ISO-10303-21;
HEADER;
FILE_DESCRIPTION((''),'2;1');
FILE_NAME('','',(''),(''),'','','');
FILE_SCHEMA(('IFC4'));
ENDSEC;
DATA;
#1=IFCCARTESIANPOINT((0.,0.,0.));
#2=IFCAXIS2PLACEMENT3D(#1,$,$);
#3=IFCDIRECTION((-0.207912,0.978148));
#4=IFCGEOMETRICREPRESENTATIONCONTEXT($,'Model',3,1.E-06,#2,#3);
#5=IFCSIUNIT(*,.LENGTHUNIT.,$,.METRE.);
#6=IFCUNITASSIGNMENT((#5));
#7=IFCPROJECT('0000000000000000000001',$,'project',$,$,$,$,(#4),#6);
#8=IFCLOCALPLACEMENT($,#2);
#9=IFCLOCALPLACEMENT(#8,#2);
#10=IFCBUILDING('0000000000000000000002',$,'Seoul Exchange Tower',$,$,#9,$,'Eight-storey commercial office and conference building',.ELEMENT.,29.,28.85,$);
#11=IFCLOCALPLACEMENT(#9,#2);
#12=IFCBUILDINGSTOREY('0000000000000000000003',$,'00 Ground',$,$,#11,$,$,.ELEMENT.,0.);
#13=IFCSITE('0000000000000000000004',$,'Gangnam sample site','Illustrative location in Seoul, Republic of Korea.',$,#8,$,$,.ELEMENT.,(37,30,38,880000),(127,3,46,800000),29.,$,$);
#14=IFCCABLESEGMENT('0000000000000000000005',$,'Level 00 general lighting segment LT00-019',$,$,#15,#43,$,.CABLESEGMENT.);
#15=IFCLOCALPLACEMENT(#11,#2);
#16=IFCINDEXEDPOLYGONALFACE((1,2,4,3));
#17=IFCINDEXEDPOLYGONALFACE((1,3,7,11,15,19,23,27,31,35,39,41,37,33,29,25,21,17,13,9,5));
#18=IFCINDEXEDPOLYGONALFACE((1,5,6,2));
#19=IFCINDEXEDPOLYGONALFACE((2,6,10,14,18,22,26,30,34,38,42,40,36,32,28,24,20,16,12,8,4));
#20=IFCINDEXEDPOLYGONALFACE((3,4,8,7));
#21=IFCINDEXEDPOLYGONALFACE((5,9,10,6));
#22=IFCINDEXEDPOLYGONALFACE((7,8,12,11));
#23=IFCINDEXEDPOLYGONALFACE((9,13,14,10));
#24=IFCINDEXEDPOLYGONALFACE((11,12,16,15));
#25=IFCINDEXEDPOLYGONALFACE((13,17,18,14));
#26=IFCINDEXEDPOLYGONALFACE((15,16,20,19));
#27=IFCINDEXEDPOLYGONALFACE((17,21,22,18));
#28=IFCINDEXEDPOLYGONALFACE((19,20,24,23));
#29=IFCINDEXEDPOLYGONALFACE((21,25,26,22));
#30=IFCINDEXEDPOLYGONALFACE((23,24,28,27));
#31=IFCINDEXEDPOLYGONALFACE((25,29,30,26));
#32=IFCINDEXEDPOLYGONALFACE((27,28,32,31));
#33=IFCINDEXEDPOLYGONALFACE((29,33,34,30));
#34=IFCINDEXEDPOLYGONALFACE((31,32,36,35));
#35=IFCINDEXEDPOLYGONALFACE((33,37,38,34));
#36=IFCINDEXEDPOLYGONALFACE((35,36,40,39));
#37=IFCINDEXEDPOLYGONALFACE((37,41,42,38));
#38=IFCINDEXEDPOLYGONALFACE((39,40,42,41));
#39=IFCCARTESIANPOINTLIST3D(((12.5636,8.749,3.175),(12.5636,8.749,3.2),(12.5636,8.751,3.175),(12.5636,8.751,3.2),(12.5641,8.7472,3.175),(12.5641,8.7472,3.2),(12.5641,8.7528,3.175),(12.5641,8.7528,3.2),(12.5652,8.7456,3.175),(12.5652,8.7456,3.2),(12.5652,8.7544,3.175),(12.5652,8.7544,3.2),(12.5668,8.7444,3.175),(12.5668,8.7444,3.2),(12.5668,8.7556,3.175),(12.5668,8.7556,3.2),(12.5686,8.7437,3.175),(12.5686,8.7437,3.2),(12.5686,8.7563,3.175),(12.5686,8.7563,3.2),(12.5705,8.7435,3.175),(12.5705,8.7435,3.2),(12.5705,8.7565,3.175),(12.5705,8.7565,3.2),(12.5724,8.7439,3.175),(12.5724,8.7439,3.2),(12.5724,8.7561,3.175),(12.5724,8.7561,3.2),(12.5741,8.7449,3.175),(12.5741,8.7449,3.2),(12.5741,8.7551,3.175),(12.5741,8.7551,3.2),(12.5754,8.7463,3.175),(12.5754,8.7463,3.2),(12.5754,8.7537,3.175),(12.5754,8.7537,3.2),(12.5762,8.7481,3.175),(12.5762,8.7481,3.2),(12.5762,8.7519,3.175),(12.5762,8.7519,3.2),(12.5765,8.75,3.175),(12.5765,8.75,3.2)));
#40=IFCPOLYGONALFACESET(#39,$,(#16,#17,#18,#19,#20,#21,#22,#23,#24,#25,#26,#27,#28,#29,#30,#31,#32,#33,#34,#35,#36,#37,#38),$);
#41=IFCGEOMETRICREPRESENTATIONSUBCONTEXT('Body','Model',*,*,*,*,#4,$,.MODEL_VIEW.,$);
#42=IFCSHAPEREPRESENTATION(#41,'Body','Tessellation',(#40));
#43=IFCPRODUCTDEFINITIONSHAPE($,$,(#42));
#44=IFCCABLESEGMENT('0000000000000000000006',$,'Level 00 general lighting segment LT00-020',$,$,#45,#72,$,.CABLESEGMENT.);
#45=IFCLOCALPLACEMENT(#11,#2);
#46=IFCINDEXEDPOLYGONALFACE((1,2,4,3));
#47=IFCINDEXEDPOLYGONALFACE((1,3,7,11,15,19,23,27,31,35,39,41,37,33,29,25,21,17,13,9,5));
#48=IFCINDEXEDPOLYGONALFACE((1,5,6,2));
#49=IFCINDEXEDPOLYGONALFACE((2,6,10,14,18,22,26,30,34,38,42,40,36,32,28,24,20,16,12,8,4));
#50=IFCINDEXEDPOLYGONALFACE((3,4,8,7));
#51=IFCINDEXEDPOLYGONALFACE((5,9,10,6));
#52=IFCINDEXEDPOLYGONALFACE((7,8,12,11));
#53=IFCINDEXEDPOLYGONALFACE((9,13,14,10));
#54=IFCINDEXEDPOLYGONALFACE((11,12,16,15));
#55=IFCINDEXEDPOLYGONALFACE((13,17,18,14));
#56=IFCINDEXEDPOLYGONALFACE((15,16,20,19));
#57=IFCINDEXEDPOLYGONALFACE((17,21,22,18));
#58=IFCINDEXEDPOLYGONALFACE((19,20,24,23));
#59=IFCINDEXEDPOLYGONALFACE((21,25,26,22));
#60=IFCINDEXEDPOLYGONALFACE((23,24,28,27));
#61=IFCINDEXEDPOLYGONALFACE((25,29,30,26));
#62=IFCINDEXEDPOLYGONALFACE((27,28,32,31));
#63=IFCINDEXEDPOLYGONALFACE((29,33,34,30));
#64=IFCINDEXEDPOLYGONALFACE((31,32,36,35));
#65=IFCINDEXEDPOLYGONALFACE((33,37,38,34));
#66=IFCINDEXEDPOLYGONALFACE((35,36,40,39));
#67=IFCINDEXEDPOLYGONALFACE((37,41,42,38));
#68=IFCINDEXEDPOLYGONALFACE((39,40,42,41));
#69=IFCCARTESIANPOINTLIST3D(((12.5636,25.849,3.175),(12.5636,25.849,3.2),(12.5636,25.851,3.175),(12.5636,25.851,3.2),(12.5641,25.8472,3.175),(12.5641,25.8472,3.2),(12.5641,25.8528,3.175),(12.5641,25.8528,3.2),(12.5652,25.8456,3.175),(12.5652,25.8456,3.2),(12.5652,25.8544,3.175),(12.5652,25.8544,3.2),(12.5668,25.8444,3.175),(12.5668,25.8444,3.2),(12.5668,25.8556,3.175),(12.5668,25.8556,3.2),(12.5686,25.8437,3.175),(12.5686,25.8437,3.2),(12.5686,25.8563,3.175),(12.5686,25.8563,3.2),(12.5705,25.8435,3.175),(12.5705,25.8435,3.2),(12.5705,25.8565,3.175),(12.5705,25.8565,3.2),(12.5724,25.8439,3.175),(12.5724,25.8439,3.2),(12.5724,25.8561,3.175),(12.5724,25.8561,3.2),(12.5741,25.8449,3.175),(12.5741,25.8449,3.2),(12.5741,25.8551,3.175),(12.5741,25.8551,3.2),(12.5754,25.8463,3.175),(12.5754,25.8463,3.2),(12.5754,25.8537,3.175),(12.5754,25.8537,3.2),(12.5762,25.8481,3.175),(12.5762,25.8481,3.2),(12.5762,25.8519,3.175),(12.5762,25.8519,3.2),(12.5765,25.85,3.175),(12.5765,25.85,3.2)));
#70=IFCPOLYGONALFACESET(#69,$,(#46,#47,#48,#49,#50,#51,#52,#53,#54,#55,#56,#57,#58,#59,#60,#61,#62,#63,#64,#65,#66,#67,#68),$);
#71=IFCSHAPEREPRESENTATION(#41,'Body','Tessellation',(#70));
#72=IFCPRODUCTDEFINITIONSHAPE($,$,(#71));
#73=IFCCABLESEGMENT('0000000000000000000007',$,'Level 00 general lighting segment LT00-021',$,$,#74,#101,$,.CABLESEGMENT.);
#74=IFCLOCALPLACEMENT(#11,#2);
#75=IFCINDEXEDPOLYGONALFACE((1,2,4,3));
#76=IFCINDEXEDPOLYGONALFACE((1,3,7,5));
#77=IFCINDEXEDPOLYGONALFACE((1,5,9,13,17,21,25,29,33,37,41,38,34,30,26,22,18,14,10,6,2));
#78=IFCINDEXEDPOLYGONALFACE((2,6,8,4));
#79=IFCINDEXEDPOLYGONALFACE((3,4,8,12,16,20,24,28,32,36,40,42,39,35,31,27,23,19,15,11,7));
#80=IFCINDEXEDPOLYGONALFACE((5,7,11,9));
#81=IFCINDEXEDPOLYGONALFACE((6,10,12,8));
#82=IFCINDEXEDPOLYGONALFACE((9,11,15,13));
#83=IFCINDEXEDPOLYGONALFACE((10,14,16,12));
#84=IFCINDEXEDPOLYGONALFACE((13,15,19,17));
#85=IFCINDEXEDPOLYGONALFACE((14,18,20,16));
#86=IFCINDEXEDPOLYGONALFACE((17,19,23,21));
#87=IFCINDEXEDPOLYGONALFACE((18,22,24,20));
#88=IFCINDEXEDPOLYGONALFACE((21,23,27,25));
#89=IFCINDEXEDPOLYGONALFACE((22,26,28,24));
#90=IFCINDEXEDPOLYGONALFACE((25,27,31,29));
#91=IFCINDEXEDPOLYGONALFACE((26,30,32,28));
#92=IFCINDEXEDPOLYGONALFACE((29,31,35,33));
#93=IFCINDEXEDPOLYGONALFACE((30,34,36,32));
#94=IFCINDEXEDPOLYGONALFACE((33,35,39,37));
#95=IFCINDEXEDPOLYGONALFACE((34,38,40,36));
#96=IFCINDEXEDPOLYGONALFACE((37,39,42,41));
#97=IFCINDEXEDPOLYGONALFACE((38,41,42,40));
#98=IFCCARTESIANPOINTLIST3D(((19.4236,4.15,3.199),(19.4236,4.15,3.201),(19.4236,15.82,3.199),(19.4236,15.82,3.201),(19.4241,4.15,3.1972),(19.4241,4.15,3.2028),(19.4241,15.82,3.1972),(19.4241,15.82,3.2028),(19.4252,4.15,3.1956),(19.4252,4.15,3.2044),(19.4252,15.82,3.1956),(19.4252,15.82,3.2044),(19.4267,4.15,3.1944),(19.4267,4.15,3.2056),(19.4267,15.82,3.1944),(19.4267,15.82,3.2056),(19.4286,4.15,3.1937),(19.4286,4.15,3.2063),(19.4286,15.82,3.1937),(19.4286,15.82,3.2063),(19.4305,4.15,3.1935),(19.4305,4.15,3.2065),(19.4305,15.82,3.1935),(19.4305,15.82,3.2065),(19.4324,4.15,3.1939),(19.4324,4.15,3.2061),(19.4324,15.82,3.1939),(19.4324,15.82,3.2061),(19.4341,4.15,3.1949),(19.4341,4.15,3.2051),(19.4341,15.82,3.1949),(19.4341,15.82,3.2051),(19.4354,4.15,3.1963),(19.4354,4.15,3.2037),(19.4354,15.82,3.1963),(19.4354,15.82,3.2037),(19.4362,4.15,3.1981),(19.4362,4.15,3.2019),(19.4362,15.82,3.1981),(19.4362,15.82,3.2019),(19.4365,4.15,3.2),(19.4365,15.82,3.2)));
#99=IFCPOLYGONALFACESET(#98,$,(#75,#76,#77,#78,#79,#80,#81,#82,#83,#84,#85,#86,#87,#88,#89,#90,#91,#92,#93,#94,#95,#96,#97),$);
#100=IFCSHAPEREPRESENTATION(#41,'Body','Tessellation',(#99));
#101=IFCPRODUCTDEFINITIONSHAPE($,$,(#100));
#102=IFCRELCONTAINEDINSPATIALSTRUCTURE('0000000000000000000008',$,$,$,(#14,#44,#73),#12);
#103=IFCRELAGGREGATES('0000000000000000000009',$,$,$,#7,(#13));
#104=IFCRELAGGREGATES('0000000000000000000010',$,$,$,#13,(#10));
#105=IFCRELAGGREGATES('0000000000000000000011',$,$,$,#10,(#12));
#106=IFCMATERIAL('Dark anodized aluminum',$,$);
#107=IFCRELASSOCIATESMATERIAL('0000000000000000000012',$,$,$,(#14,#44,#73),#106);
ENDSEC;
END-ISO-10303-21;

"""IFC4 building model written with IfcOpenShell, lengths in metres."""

from ifc_helpers import new_model, si_unit, direction, frame, origin, place, context, subcontext, project, spatial, circle, extrude, material, element, save


model = new_model("IFC4")

# Units and contexts
model_context = context("Model", 3, precision=1e-06, world=origin(), true_north=direction((-0.207912, 0.978148)))
body_context = subcontext(model_context, "Body", "Model", "MODEL_VIEW")
ifc_project = project(units=[si_unit("LENGTHUNIT", "METRE")], contexts=[model_context])

# Site, building, storey
site_placement = place(None, origin())
site = spatial("IfcSite", under=ifc_project, at=site_placement, Name="Gangnam sample site", Description="Illustrative location in Seoul, Republic of Korea.", CompositionType="ELEMENT", RefLatitude=(37, 30, 38, 880000), RefLongitude=(127, 3, 46, 800000), RefElevation=29.0)
building_placement = place(site_placement, origin())
building = spatial("IfcBuilding", under=site, at=building_placement, Name="Seoul Exchange Tower", LongName="Eight-storey commercial office and conference building", CompositionType="ELEMENT", ElevationOfRefHeight=29.0, ElevationOfTerrain=28.85)
storey_placement = place(building_placement, origin())
storey = spatial("IfcBuildingStorey", under=building, at=storey_placement, Name="00 Ground", CompositionType="ELEMENT", Elevation=0.0)

# Shared definitions
ifc_material = material(Name="Dark anodized aluminum")
placement = place(storey_placement, origin())

# Cable segments
element("IfcCableSegment", 1, at=placement, inside=storey, material=ifc_material, Name="Level 00 general lighting segment LT00-019", PredefinedType="CABLESEGMENT", context=body_context, shape_type="SweptSolid", body=[
    extrude(circle(Radius=0.0065), frame((12.57, 8.75, 3.2), z_axis=(0.0, 0.0, -1.0), x_axis=(1.0, 0.0, 0.0)), (0.0, 0.0, 1.0), 0.025),
])
element("IfcCableSegment", 2, at=placement, inside=storey, material=ifc_material, Name="Level 00 general lighting segment LT00-020", PredefinedType="CABLESEGMENT", context=body_context, shape_type="SweptSolid", body=[
    extrude(circle(Radius=0.0065), frame((12.57, 25.85, 3.2), z_axis=(0.0, 0.0, -1.0), x_axis=(1.0, 0.0, 0.0)), (0.0, 0.0, 1.0), 0.025),
])
element("IfcCableSegment", 3, at=placement, inside=storey, material=ifc_material, Name="Level 00 general lighting segment LT00-021", PredefinedType="CABLESEGMENT", context=body_context, shape_type="SweptSolid", body=[
    extrude(circle(Radius=0.0065), frame((19.43, 15.82, 3.2), z_axis=(0.0, -1.0, 0.0), x_axis=(1.0, 0.0, 0.0)), (0.0, 0.0, 1.0), 11.67),
])

save(model, "model.ifc")
